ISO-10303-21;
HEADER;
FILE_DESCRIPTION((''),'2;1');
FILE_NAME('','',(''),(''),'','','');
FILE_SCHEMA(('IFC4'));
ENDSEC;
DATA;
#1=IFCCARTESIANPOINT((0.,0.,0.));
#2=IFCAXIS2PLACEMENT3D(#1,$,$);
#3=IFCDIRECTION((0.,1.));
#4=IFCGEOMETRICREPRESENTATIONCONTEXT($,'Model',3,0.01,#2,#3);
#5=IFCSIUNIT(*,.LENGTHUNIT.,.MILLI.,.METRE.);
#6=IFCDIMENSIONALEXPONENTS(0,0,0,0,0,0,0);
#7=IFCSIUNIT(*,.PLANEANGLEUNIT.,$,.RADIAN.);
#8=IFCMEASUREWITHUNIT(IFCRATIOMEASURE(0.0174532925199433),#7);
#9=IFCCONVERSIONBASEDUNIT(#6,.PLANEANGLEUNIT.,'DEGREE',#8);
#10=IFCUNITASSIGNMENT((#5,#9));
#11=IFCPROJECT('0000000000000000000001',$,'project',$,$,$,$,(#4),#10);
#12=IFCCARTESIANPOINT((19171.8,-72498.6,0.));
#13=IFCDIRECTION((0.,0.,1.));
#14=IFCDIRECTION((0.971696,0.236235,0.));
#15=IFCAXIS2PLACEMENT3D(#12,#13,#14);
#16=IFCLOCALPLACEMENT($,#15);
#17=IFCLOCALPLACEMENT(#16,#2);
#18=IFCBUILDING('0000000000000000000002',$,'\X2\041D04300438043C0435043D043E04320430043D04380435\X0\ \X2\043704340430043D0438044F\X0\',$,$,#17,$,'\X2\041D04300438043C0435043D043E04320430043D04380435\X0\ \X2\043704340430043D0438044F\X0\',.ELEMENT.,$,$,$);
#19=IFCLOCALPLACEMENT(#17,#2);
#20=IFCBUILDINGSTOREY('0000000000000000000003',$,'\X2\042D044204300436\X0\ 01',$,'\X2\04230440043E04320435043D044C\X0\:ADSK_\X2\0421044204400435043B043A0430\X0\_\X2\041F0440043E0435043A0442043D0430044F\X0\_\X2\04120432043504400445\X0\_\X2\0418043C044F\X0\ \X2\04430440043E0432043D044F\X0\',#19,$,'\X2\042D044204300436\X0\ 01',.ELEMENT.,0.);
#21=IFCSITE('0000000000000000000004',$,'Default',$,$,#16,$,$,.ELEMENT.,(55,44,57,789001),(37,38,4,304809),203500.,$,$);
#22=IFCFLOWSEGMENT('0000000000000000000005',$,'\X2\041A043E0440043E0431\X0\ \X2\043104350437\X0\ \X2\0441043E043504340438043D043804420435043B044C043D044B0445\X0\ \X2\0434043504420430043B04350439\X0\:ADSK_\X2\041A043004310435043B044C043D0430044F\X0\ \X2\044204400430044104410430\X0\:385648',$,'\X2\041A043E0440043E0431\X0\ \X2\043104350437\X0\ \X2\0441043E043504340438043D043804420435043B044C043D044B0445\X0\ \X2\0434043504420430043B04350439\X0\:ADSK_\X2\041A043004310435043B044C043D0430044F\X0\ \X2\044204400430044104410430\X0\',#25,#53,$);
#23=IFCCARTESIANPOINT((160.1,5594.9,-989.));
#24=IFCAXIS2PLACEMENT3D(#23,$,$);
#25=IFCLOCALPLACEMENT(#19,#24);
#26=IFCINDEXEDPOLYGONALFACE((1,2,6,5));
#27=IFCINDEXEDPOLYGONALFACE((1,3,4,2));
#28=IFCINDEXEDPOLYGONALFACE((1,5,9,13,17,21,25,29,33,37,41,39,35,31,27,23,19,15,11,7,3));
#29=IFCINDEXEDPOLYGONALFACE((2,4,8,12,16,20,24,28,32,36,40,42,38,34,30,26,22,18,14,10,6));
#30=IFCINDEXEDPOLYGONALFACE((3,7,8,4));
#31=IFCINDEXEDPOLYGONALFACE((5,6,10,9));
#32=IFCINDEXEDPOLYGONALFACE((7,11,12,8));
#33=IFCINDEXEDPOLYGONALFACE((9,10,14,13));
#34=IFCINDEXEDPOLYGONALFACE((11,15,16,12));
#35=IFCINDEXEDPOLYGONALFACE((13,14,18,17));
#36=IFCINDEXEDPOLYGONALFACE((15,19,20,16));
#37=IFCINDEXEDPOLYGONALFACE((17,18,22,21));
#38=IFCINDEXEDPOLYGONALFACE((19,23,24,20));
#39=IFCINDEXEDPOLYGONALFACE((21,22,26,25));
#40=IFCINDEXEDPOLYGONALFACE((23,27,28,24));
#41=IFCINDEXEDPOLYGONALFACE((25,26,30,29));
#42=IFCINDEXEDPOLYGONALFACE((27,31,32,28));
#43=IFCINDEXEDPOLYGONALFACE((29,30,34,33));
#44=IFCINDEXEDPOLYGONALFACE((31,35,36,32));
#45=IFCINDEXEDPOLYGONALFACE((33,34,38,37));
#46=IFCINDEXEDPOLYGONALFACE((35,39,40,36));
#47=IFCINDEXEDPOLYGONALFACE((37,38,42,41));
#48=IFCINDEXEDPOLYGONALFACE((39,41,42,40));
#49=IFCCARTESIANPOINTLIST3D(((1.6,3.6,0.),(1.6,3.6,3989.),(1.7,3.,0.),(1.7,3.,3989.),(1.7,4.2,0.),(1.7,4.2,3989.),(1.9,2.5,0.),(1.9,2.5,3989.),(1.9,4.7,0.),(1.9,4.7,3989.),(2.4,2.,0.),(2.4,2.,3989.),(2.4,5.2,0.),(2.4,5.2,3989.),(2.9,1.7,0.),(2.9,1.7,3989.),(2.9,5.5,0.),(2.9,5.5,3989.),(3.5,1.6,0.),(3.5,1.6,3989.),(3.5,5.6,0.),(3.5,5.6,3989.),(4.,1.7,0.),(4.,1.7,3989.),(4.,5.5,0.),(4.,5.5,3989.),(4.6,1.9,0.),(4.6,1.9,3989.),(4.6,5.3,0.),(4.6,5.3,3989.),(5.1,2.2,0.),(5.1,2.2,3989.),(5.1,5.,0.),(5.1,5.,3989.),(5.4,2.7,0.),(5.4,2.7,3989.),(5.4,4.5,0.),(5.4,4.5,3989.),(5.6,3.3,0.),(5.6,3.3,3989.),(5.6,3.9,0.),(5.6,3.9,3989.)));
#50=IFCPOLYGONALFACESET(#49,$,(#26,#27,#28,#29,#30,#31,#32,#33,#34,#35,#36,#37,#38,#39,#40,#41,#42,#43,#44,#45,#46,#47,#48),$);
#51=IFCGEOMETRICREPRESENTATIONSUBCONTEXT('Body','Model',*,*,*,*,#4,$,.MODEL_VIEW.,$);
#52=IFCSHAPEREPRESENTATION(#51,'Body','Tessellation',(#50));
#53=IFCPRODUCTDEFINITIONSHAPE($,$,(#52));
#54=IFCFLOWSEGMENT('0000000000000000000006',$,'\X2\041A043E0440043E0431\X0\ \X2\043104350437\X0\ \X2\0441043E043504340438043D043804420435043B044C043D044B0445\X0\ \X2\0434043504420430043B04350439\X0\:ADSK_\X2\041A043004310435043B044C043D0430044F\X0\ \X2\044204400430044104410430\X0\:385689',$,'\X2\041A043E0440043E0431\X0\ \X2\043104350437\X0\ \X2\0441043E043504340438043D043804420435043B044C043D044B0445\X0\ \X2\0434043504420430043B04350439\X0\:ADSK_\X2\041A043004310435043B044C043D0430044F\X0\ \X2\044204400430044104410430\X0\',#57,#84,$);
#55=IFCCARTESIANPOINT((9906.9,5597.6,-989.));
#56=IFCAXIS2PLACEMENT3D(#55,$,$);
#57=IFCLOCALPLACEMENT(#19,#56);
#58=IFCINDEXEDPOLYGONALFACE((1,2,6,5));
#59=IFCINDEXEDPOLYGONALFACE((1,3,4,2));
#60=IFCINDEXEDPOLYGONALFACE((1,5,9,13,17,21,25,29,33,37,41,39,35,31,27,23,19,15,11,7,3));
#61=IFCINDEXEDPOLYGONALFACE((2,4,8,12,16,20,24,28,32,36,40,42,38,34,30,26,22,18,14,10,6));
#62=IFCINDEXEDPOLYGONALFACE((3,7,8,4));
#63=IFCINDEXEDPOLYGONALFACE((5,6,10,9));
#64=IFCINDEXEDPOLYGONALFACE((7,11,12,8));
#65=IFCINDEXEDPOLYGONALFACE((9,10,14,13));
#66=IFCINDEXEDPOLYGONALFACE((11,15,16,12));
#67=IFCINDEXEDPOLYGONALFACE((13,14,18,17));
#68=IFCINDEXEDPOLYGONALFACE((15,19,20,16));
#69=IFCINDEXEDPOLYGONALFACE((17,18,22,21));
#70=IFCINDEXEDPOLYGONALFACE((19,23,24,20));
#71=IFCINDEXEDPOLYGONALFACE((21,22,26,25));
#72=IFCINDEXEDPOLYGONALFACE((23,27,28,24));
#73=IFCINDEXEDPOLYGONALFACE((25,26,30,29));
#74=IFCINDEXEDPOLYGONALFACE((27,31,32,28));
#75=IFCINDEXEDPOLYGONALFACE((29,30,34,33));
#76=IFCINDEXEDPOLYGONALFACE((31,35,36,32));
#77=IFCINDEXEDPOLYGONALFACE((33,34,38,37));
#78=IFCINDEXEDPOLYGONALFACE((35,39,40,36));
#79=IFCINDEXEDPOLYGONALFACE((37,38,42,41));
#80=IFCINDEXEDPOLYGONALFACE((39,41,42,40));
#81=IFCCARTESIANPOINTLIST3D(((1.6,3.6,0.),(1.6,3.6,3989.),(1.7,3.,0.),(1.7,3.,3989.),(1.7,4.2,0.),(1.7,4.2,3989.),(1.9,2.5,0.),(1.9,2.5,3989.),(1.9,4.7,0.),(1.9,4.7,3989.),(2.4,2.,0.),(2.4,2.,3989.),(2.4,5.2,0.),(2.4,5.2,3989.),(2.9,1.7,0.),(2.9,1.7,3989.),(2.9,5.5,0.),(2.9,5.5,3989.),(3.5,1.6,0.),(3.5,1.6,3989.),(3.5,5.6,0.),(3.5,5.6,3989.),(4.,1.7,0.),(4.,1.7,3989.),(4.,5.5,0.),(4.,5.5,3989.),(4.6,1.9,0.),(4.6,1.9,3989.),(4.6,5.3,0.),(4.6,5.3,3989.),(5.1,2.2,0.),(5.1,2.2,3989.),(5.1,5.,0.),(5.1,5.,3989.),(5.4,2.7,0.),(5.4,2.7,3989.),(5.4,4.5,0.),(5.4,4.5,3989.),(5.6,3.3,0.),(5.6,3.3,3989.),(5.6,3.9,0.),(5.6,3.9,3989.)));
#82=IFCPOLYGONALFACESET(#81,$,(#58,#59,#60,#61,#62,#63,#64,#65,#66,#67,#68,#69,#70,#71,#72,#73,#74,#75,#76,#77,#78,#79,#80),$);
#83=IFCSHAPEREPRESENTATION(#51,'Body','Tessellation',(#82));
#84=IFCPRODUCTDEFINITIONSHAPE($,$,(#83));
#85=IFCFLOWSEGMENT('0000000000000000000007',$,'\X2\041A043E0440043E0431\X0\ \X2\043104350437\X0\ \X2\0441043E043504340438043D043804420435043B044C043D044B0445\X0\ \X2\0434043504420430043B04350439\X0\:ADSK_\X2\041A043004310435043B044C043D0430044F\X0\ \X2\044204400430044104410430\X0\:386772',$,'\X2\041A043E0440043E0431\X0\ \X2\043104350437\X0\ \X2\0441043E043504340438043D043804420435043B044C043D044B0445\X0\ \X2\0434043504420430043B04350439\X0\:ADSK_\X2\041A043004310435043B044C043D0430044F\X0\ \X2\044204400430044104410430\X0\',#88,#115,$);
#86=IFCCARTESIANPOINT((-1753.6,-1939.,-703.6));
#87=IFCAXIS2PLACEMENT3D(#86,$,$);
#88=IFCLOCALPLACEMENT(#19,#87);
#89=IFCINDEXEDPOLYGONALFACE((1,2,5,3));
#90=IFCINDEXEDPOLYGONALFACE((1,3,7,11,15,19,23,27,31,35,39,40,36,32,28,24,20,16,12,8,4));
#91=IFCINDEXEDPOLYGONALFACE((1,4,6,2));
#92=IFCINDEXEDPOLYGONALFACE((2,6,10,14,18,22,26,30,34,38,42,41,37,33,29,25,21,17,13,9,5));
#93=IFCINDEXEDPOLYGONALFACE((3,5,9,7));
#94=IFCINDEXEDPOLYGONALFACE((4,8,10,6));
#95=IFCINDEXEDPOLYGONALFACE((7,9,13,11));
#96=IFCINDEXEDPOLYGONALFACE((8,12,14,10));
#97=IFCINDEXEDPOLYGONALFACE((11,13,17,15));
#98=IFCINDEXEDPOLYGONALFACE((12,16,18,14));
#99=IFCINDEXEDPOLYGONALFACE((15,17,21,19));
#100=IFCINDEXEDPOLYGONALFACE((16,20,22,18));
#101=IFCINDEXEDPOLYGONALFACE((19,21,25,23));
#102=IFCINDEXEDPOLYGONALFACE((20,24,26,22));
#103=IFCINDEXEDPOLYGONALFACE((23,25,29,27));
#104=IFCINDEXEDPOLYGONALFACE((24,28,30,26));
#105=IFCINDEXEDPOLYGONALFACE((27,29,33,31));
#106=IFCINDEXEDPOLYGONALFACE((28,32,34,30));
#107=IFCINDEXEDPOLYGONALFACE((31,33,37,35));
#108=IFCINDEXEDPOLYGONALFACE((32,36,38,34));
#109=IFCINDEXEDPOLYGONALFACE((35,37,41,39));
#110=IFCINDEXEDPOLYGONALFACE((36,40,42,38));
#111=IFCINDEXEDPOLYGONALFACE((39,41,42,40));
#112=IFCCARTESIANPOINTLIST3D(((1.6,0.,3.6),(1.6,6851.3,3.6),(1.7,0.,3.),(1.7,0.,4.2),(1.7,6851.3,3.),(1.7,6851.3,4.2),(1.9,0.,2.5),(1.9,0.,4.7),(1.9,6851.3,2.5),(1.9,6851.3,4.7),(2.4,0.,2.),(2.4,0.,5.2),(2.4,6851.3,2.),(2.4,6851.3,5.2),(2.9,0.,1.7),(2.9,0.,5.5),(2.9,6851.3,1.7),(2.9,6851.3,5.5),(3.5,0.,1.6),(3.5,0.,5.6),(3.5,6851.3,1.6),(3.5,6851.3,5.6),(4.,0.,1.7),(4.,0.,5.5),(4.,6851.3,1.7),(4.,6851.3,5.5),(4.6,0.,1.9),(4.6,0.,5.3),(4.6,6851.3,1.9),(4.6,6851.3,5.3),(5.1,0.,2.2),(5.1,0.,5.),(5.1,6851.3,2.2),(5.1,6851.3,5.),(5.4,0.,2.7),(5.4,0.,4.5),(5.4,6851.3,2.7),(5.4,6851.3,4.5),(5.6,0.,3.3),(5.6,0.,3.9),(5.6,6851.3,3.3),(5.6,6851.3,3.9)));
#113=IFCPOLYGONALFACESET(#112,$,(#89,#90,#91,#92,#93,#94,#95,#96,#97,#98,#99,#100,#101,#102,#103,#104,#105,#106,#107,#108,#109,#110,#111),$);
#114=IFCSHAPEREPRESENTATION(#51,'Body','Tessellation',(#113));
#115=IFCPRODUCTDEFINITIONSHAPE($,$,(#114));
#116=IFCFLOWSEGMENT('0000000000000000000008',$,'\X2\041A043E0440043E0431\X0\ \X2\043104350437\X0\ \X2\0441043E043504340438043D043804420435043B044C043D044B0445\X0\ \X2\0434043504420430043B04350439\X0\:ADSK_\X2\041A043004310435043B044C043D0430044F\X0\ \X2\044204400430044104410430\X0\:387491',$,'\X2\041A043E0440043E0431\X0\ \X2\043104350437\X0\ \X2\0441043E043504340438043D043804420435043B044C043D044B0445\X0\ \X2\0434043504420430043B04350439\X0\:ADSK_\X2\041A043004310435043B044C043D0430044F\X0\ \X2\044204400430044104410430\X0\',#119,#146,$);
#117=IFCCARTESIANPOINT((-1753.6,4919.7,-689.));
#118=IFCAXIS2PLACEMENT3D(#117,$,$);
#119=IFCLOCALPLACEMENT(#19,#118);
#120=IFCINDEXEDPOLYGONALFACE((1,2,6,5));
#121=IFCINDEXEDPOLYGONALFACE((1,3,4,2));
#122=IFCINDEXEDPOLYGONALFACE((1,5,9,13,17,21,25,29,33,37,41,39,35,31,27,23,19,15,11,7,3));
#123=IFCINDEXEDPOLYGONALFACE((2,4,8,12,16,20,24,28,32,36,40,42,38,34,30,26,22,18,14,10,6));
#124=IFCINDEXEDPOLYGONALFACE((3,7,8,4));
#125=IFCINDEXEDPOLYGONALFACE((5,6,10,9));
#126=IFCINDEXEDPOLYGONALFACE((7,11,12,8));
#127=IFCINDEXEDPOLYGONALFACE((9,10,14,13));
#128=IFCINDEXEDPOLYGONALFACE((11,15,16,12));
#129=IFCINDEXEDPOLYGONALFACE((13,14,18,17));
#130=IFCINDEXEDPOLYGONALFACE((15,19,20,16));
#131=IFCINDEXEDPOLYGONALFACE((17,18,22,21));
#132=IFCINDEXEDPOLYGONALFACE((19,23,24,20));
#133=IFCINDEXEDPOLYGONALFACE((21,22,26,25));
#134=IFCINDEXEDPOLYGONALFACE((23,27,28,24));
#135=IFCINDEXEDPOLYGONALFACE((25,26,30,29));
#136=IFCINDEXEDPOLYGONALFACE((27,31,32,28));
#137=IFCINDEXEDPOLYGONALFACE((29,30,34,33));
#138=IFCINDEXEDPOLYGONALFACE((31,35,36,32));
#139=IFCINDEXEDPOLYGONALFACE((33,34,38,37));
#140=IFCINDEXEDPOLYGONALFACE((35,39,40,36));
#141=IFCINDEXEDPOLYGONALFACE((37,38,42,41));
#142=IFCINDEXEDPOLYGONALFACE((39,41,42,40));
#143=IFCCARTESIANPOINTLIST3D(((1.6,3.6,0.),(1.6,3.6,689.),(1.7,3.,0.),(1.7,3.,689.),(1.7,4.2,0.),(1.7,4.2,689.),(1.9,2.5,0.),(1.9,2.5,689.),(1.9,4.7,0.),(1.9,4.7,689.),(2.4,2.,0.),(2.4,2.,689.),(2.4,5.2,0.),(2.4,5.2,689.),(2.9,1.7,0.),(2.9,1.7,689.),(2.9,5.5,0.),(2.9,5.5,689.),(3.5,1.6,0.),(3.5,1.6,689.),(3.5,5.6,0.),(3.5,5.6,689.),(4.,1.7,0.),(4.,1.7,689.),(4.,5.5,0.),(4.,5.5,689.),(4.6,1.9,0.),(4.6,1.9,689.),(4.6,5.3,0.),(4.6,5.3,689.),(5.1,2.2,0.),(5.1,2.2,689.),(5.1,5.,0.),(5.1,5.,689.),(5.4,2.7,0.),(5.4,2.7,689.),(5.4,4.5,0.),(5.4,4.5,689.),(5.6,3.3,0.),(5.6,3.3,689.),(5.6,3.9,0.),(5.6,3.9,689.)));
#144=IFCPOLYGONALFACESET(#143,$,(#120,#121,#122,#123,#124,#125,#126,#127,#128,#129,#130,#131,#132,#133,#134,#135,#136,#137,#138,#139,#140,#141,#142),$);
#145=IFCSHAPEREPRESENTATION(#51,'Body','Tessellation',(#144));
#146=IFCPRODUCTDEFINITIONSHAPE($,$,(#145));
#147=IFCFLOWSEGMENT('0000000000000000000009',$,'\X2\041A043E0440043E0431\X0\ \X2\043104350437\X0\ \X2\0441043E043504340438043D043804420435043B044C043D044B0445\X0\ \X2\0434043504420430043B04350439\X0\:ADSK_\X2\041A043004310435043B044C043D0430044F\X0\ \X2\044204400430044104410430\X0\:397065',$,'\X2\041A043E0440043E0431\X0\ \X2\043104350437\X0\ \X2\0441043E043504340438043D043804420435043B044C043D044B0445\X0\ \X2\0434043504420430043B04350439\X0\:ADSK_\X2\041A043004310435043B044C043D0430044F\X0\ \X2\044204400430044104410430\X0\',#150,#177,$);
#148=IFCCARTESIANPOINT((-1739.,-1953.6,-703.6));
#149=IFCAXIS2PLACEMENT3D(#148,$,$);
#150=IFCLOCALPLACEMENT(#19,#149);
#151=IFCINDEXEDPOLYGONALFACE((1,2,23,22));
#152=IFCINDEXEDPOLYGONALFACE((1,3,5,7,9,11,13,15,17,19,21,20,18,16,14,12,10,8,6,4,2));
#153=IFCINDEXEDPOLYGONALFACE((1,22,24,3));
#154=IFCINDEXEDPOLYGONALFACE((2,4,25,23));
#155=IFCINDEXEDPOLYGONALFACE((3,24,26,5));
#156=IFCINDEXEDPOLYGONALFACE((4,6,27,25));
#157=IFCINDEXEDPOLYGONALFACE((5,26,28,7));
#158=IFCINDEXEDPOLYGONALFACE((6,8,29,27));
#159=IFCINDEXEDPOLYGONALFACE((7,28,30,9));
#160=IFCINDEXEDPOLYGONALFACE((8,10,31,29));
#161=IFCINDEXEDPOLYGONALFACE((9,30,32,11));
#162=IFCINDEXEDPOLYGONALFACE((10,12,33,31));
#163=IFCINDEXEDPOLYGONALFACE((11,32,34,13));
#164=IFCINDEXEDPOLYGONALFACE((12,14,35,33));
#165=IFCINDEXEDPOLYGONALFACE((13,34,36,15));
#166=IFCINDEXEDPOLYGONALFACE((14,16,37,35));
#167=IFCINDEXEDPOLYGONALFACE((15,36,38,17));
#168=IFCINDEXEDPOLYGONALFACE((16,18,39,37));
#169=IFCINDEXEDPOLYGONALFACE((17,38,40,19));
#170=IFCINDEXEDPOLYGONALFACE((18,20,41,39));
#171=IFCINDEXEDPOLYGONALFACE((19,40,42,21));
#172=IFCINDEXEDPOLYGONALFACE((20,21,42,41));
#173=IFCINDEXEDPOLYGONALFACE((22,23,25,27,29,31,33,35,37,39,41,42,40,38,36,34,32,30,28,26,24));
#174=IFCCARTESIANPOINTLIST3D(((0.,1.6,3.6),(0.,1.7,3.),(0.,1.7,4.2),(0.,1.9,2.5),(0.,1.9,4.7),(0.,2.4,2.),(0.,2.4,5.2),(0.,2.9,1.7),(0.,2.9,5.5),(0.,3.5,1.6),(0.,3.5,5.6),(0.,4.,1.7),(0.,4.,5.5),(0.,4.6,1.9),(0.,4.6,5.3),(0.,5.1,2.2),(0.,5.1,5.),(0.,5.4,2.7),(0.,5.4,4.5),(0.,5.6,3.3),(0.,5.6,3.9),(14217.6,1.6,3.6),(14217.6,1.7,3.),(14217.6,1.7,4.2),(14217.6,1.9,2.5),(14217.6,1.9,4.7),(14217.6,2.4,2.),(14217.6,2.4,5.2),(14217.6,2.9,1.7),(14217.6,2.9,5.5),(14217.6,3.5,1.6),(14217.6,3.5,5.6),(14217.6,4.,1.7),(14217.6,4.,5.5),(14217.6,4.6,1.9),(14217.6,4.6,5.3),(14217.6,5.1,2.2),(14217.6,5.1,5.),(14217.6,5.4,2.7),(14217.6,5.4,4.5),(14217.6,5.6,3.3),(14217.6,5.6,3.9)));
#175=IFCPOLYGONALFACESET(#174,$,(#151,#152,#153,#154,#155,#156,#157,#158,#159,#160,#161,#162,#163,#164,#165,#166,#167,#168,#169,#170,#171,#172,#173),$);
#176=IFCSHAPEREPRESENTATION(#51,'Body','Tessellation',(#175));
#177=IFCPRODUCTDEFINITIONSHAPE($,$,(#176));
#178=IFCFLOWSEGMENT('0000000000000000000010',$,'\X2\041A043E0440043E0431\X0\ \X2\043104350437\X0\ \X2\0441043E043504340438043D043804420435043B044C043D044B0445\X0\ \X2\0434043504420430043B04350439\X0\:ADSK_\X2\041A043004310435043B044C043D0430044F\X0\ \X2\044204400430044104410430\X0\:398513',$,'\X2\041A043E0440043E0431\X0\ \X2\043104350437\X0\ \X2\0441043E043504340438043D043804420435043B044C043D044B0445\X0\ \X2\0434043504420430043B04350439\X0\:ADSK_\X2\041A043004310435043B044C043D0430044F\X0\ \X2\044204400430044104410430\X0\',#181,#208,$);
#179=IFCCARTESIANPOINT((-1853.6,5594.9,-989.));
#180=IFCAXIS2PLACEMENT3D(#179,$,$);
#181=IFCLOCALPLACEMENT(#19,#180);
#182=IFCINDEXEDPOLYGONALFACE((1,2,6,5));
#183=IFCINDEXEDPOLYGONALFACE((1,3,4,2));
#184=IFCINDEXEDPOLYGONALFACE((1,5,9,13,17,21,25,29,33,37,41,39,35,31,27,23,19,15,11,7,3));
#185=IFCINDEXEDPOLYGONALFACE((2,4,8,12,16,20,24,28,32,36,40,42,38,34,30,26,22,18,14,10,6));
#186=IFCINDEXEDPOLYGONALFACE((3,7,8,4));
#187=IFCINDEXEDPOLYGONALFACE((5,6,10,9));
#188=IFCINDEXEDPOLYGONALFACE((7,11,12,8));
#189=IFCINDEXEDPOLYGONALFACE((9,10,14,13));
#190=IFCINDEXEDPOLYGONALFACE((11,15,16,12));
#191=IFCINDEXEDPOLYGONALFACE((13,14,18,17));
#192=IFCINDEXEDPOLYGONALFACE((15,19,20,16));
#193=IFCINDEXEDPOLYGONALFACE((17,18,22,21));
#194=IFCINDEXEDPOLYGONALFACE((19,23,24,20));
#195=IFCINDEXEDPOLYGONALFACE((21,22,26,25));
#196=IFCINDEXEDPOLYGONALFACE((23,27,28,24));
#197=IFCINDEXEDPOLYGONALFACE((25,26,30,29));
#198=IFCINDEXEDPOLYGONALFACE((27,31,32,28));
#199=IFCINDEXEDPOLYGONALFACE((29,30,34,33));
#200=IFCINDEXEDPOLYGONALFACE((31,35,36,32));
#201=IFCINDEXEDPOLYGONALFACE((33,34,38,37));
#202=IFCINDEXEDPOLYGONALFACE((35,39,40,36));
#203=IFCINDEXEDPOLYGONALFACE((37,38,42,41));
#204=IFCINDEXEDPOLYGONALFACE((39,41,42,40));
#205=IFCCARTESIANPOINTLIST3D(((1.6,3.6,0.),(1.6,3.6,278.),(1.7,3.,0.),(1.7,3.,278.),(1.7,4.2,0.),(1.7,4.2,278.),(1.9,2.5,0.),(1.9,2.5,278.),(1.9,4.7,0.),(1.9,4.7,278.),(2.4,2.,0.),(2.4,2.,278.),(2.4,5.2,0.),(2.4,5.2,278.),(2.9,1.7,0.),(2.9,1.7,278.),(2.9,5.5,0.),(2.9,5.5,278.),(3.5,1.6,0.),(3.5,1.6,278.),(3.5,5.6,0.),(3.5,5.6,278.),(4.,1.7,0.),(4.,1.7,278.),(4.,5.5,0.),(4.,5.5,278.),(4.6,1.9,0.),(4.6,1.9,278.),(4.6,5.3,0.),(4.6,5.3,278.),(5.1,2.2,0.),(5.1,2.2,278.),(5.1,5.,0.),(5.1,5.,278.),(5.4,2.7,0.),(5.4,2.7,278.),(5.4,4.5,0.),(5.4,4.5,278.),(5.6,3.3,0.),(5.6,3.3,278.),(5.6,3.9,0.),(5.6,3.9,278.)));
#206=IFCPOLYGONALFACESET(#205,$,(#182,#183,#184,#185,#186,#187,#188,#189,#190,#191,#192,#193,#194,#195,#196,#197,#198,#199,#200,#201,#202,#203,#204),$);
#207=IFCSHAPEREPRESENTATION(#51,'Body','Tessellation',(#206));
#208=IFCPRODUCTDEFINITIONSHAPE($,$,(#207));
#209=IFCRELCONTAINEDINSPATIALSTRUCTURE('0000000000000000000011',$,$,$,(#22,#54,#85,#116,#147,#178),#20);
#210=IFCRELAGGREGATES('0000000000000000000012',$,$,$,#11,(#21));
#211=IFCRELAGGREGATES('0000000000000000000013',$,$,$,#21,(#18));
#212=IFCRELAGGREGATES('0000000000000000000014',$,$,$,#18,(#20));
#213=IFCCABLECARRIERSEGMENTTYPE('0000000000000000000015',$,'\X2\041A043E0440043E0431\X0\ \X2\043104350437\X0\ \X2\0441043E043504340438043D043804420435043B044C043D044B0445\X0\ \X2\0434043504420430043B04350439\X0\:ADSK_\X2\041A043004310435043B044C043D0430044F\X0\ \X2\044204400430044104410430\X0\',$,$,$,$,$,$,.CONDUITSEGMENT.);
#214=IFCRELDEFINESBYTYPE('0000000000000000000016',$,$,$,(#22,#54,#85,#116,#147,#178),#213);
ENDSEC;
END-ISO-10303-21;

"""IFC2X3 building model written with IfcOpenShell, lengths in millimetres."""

from ifc_helpers import new_model, entity, si_unit, converted_unit, direction, frame, origin, origin_2d_with_axis, place, context, subcontext, project, spatial, circle, extrude, type_object, element, save


model = new_model("IFC2X3")

# Units and contexts
model_context = context("Model", 3, precision=0.01, world=origin(), true_north=direction((0.0, 1.0)))
body_context = subcontext(model_context, "Body", "Model", "MODEL_VIEW")
ifc_project = project(units=[si_unit("LENGTHUNIT", "METRE", prefix="MILLI"), converted_unit("PLANEANGLEUNIT", "DEGREE", entity("IfcRatioMeasure", 0.0174532925199433), si_unit("PLANEANGLEUNIT", "RADIAN"), dimensions=[0, 0, 0, 0, 0, 0, 0])], contexts=[model_context])

# Site, building, storey
site_placement = place(None, frame((19171.8, -72498.6, 0.0), z_axis=(0.0, 0.0, 1.0), x_axis=(0.971696, 0.236235, 0.0)))
site = spatial("IfcSite", under=ifc_project, at=site_placement, Name="Default", CompositionType="ELEMENT", RefLatitude=(55, 44, 57, 789001), RefLongitude=(37, 38, 4, 304809), RefElevation=203500.0)
building_placement = place(site_placement, origin())
building = spatial("IfcBuilding", under=site, at=building_placement, Name="Наименование здания", LongName="Наименование здания", CompositionType="ELEMENT")
storey_placement = place(building_placement, origin())
storey = spatial("IfcBuildingStorey", under=building, at=storey_placement, Name="Этаж 01", ObjectType="Уровень:ADSK_Стрелка_Проектная_Вверх_Имя уровня", LongName="Этаж 01", CompositionType="ELEMENT", Elevation=0.0)

# Flow segments
cable_carrier_segment_type_1 = type_object("IfcCableCarrierSegmentType", Name="Короб без соединительных деталей:ADSK_Кабельная трасса", PredefinedType="CONDUITSEGMENT")
for number, where, name in (
    (1, (160.1, 5594.9, -989.0), "Короб без соединительных деталей:ADSK_Кабельная трасса:385648"),
    (2, (9906.9, 5597.6, -989.0), "Короб без соединительных деталей:ADSK_Кабельная трасса:385689"),
):
    element("IfcFlowSegment", number, at=place(storey_placement, frame(where)), inside=storey, type_object=cable_carrier_segment_type_1, Name=name, ObjectType="Короб без соединительных деталей:ADSK_Кабельная трасса", context=body_context, shape_type="SweptSolid", body=[
        extrude(circle(Radius=2.0, at=origin_2d_with_axis()), frame((3.6, 3.6, 0.0), z_axis=(0.0, 0.0, 1.0), x_axis=(-1.0, 0.0, 0.0)), (0.0, 0.0, 1.0), 3989.0),
    ])
flow_segment_1_placement = place(storey_placement, frame((-1753.6, -1939.0, -703.6)))
element("IfcFlowSegment", 3, at=flow_segment_1_placement, inside=storey, type_object=cable_carrier_segment_type_1, Name="Короб без соединительных деталей:ADSK_Кабельная трасса:386772", ObjectType="Короб без соединительных деталей:ADSK_Кабельная трасса", context=body_context, shape_type="SweptSolid", body=[
    extrude(circle(Radius=2.0, at=origin_2d_with_axis()), frame((3.6, 0.0, 3.6), z_axis=(0.0, 1.0, 0.0), x_axis=(-1.0, 0.0, 0.0)), (0.0, 0.0, 1.0), 6851.3),
])
flow_segment_2_placement = place(storey_placement, frame((-1753.6, 4919.7, -689.0)))
element("IfcFlowSegment", 4, at=flow_segment_2_placement, inside=storey, type_object=cable_carrier_segment_type_1, Name="Короб без соединительных деталей:ADSK_Кабельная трасса:387491", ObjectType="Короб без соединительных деталей:ADSK_Кабельная трасса", context=body_context, shape_type="SweptSolid", body=[
    extrude(circle(Radius=2.0, at=origin_2d_with_axis()), frame((3.6, 3.6, 0.0), z_axis=(0.0, 0.0, 1.0), x_axis=(-1.0, 0.0, 0.0)), (0.0, 0.0, 1.0), 689.0),
])
flow_segment_3_placement = place(storey_placement, frame((-1739.0, -1953.6, -703.6)))
element("IfcFlowSegment", 5, at=flow_segment_3_placement, inside=storey, type_object=cable_carrier_segment_type_1, Name="Короб без соединительных деталей:ADSK_Кабельная трасса:397065", ObjectType="Короб без соединительных деталей:ADSK_Кабельная трасса", context=body_context, shape_type="SweptSolid", body=[
    extrude(circle(Radius=2.0, at=origin_2d_with_axis()), frame((0.0, 3.6, 3.6), z_axis=(1.0, 0.0, 0.0), x_axis=(0.0, -1.0, 0.0)), (0.0, 0.0, 1.0), 14217.6),
])
flow_segment_4_placement = place(storey_placement, frame((-1853.6, 5594.9, -989.0)))
element("IfcFlowSegment", 6, at=flow_segment_4_placement, inside=storey, type_object=cable_carrier_segment_type_1, Name="Короб без соединительных деталей:ADSK_Кабельная трасса:398513", ObjectType="Короб без соединительных деталей:ADSK_Кабельная трасса", context=body_context, shape_type="SweptSolid", body=[
    extrude(circle(Radius=2.0, at=origin_2d_with_axis()), frame((3.6, 3.6, 0.0), z_axis=(0.0, 0.0, 1.0), x_axis=(-1.0, 0.0, 0.0)), (0.0, 0.0, 1.0), 278.0),
])

save(model, "model.ifc")
